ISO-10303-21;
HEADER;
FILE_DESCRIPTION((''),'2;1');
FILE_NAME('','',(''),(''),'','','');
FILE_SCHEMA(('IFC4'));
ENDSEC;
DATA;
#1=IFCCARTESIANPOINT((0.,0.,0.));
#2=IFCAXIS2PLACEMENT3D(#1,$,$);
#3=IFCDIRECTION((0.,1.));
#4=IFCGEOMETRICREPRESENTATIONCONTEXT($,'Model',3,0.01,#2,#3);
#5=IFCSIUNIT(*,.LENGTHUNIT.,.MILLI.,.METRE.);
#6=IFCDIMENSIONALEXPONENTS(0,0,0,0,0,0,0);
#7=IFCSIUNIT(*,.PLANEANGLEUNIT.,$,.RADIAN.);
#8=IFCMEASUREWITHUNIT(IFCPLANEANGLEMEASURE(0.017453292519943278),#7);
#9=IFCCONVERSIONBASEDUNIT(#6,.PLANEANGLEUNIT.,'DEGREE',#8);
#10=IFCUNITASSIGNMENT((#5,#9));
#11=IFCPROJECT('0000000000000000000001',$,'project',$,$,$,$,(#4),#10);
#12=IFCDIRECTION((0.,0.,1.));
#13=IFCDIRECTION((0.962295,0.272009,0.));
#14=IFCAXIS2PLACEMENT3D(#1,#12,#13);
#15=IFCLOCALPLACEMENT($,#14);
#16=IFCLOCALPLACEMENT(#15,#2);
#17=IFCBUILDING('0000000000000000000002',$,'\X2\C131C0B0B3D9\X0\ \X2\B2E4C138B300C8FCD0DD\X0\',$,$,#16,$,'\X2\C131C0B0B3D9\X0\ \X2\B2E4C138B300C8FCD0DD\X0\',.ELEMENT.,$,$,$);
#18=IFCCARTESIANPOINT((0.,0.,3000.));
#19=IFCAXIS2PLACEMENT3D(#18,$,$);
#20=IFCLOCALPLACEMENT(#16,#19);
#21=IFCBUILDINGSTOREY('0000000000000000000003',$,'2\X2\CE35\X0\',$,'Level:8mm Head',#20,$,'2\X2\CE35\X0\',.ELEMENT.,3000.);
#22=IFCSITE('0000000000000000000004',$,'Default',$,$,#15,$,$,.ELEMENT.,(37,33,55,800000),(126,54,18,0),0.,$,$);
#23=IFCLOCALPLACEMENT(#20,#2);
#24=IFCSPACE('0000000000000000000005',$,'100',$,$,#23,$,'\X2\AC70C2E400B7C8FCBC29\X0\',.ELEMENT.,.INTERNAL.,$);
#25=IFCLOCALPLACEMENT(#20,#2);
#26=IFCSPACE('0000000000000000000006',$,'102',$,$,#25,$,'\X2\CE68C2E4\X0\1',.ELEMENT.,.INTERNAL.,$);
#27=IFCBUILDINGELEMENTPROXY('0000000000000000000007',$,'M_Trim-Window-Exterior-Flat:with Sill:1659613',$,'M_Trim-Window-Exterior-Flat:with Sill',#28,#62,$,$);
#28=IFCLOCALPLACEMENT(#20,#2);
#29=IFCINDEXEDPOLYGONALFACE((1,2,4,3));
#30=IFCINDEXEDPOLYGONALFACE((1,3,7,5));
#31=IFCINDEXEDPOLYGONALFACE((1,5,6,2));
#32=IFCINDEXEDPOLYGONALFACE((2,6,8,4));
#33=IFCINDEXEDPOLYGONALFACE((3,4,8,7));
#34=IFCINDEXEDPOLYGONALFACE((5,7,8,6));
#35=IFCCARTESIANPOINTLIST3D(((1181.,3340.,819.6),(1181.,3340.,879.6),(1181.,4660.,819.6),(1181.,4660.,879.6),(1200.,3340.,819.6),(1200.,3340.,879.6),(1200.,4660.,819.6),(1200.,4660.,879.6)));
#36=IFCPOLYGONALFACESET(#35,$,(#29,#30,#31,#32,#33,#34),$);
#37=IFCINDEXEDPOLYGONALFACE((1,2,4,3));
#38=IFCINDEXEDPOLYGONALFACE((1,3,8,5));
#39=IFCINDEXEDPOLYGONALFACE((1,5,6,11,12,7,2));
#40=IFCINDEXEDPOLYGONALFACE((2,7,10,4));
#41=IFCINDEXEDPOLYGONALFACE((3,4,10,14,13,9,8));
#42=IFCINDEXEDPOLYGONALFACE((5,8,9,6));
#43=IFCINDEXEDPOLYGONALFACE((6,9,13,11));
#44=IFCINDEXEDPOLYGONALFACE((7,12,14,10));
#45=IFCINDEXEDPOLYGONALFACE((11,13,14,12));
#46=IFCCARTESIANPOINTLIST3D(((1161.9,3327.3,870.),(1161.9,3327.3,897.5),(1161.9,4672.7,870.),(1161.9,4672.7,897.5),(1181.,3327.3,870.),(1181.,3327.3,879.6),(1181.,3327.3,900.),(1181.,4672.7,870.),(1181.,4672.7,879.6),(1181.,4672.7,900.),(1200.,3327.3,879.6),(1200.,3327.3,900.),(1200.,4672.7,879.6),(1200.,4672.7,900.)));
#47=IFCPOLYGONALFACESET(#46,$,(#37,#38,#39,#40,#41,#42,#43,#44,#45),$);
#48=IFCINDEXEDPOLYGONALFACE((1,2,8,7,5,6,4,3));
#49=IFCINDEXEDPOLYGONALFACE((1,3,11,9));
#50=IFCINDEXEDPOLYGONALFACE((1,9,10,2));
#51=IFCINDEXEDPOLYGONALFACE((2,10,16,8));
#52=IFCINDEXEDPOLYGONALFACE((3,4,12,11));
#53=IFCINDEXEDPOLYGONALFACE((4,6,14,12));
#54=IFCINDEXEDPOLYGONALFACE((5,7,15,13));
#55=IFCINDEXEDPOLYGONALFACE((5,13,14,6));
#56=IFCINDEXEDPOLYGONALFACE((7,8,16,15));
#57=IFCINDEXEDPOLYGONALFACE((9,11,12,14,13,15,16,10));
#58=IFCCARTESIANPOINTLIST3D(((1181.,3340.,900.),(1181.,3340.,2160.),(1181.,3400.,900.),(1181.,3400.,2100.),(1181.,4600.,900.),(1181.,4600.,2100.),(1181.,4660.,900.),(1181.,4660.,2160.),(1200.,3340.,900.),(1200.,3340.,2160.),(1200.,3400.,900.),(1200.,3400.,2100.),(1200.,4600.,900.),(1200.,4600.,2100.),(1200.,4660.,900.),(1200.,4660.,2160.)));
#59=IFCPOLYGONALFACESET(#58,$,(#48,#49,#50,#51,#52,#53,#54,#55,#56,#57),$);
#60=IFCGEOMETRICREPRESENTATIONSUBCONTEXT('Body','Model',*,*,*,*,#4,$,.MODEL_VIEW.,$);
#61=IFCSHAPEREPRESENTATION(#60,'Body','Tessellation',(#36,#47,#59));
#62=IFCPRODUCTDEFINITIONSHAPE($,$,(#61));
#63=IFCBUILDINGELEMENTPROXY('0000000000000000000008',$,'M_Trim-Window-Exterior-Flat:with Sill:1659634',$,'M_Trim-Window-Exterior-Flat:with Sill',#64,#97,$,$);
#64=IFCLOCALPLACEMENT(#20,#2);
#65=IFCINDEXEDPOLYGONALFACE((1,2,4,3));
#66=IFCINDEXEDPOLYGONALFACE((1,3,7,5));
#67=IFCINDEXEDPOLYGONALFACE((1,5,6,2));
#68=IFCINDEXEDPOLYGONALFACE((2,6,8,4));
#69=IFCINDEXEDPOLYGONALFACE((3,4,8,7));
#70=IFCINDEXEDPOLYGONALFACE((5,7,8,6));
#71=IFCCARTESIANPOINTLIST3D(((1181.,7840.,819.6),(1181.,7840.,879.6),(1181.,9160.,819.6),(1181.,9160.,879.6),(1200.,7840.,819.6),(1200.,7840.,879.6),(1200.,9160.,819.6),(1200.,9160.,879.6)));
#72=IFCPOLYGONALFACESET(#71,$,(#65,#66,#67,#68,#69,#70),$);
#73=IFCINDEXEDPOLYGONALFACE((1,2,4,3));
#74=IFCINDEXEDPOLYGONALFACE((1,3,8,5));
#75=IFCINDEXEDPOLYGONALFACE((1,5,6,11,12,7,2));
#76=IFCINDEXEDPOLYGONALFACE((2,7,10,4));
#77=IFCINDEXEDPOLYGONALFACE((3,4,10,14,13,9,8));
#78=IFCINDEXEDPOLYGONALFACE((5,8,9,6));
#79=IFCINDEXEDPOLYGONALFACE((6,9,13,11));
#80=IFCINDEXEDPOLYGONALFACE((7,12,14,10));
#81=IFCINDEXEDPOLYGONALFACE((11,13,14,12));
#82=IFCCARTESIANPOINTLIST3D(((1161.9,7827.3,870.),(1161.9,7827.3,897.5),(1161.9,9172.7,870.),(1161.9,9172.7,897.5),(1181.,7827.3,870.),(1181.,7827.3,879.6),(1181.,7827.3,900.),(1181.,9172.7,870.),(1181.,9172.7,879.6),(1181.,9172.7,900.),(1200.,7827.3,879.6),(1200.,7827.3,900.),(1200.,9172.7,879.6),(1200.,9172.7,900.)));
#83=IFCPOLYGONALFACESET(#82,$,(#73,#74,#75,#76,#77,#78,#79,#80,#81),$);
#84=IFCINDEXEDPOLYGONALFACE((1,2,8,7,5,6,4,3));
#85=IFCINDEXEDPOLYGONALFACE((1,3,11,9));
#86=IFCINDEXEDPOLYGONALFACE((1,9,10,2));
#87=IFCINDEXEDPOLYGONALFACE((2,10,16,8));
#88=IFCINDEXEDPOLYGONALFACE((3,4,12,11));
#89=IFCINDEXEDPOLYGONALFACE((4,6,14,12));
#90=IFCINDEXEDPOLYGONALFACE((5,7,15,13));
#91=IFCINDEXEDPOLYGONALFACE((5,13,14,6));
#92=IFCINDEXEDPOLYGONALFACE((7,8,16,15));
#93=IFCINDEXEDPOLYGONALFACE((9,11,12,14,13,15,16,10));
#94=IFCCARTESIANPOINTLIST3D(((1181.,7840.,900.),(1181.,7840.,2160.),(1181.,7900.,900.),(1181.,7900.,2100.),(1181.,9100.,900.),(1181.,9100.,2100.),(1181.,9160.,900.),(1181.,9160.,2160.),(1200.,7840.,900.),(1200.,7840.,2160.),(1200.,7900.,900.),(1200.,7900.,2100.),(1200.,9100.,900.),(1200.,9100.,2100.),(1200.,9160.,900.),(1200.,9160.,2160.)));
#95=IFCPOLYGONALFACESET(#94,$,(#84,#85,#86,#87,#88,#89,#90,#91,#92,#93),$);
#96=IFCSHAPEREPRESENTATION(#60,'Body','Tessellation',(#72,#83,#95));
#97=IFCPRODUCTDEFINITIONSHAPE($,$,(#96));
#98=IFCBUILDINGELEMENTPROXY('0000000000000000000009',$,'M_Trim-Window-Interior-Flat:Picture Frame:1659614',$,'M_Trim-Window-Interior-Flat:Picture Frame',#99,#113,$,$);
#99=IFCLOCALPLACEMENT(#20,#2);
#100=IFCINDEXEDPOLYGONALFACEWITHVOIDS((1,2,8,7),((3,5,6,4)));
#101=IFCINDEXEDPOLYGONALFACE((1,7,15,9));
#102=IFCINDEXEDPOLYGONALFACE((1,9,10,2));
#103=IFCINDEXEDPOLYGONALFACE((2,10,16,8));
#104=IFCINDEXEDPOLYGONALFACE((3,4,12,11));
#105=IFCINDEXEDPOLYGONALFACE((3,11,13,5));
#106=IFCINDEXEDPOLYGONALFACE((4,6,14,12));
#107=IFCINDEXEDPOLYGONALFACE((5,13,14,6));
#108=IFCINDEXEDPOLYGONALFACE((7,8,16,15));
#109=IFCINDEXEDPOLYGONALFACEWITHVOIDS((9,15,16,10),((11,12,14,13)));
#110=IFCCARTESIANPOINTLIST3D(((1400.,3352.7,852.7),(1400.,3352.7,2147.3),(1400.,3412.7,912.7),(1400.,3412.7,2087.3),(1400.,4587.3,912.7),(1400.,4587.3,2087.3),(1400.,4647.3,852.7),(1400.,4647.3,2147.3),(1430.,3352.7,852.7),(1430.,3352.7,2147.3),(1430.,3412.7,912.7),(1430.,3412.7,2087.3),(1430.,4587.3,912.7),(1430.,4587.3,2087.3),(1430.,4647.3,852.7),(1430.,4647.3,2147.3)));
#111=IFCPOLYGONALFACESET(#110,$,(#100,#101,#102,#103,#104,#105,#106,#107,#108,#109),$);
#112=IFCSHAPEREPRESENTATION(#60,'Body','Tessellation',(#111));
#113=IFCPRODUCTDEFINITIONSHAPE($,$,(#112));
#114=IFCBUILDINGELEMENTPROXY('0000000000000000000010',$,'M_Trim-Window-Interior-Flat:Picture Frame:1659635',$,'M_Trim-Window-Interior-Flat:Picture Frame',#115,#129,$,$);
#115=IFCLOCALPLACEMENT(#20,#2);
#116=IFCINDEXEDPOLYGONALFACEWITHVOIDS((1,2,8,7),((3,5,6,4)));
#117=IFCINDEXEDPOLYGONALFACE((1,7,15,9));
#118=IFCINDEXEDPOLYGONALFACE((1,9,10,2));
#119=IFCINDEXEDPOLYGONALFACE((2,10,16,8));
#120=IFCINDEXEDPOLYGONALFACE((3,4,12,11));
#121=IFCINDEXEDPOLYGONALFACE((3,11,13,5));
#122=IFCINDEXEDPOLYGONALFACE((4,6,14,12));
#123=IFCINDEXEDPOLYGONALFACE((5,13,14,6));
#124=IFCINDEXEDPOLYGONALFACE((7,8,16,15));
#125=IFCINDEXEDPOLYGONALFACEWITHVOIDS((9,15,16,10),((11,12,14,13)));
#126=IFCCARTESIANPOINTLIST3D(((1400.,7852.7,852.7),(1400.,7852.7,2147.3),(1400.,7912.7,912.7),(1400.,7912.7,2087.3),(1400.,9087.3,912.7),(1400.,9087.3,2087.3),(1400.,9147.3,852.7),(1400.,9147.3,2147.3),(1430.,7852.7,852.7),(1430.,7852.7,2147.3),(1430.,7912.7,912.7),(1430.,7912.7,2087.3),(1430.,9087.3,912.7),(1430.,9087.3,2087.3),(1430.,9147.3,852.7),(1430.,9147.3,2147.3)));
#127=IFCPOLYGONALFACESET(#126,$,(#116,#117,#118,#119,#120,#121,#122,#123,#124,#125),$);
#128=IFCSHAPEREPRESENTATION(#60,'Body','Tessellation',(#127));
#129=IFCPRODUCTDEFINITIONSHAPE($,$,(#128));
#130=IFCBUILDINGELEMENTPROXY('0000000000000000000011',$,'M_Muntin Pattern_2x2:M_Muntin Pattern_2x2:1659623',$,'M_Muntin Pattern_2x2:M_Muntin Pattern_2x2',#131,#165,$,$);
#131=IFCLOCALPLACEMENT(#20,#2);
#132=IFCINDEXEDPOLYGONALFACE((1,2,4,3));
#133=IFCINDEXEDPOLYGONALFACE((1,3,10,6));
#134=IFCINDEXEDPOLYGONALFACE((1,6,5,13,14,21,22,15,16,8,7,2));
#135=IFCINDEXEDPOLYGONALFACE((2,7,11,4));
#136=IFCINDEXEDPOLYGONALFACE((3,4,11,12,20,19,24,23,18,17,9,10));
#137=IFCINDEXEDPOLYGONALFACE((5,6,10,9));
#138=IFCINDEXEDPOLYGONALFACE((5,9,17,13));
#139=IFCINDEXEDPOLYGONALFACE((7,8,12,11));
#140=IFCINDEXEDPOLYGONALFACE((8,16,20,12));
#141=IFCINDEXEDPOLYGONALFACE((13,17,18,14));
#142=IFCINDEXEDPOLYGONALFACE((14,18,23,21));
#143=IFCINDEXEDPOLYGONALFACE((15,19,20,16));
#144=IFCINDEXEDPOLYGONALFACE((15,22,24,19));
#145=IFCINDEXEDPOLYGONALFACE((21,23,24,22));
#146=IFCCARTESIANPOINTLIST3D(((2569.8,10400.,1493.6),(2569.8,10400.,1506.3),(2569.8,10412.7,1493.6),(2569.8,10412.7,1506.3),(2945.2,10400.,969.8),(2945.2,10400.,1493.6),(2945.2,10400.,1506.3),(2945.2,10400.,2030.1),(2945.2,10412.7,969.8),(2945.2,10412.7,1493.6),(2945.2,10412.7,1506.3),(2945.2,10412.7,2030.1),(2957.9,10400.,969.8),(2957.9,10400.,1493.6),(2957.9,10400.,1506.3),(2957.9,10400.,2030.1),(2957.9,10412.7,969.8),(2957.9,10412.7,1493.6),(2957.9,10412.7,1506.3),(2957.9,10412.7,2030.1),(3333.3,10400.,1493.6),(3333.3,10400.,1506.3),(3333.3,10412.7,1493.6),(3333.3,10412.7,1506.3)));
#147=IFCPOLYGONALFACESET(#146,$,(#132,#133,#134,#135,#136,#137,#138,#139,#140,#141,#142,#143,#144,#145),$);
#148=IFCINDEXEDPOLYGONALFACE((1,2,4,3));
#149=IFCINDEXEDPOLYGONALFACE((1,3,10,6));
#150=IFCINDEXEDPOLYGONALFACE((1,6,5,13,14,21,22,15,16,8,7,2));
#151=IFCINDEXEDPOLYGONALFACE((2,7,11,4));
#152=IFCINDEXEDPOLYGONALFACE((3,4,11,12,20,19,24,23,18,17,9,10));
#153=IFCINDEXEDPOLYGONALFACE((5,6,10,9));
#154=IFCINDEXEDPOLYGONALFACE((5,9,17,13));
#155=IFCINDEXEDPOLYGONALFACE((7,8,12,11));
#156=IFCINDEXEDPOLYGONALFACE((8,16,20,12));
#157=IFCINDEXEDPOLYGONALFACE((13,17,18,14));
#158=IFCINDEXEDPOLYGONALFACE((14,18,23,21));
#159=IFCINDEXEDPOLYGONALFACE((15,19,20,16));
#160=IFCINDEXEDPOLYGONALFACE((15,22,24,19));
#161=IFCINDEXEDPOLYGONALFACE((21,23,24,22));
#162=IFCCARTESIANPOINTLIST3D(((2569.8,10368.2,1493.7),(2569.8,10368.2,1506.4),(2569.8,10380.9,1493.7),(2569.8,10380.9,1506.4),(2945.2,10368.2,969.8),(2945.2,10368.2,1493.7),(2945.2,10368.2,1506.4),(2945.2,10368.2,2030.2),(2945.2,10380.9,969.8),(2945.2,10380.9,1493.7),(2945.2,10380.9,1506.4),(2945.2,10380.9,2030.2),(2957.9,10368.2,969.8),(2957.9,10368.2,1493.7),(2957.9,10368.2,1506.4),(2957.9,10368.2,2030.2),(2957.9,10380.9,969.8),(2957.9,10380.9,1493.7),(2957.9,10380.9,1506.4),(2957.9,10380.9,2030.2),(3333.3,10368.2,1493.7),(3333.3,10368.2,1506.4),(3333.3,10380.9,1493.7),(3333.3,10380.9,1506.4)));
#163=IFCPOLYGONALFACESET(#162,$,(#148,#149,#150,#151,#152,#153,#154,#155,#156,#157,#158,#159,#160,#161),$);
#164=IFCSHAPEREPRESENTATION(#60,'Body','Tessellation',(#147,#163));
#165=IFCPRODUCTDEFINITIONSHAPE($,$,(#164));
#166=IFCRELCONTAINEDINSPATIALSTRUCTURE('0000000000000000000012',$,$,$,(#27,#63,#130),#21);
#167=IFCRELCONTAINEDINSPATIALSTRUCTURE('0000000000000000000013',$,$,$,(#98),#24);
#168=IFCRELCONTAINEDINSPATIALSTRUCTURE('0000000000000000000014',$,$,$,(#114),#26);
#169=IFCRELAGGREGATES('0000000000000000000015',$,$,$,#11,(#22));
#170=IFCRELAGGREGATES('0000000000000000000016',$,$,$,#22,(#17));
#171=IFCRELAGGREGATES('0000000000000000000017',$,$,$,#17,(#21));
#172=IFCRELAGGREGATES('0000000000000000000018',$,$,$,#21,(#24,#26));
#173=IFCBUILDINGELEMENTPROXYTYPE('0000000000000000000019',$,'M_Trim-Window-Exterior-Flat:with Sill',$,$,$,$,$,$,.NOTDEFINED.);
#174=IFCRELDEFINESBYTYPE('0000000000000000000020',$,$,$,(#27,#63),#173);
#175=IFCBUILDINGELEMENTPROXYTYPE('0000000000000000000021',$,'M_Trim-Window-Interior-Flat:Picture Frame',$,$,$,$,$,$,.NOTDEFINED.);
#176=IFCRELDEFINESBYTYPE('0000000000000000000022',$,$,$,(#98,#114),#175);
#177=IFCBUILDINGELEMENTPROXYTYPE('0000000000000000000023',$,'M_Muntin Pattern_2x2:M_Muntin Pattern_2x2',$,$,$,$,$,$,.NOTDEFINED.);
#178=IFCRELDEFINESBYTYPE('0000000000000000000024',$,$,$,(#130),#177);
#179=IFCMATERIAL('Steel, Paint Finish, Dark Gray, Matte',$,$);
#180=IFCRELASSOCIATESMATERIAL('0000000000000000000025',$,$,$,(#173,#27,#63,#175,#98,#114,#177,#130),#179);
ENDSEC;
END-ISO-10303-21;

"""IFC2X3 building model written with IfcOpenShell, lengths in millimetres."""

from ifc_helpers import new_model, entity, si_unit, converted_unit, direction, frame, frame_2d, origin, place, context, subcontext, project, spatial, polyline, rectangle, outline, extrude, source, transform, mapped, material, type_object, type_shapes, element, save


model = new_model("IFC2X3")

# Units and contexts
model_context = context("Model", 3, precision=0.01, world=origin(), true_north=direction((0.0, 1.0)))
body_context = subcontext(model_context, "Body", "Model", "MODEL_VIEW")
ifc_project = project(units=[si_unit("LENGTHUNIT", "METRE", prefix="MILLI"), converted_unit("PLANEANGLEUNIT", "DEGREE", entity("IfcPlaneAngleMeasure", 0.017453292519943278), si_unit("PLANEANGLEUNIT", "RADIAN"), dimensions=[0, 0, 0, 0, 0, 0, 0])], contexts=[model_context])

# Site, building, storey
site_placement = place(None, frame((0.0, 0.0, 0.0), z_axis=(0.0, 0.0, 1.0), x_axis=(0.962295, 0.272009, 0.0)))
site = spatial("IfcSite", under=ifc_project, at=site_placement, Name="Default", CompositionType="ELEMENT", RefLatitude=(37, 33, 55, 800000), RefLongitude=(126, 54, 18, 0), RefElevation=0.0)
building_placement = place(site_placement, origin())
building = spatial("IfcBuilding", under=site, at=building_placement, Name="성산동 다세대주택", LongName="성산동 다세대주택", CompositionType="ELEMENT")
storey_placement = place(building_placement, frame((0.0, 0.0, 3000.0)))
storey = spatial("IfcBuildingStorey", under=building, at=storey_placement, Name="2층", ObjectType="Level:8mm Head", LongName="2층", CompositionType="ELEMENT", Elevation=3000.0)

# Shared definitions
space_1_placement = place(storey_placement, origin())
space_1 = spatial("IfcSpace", under=storey, at=space_1_placement, Name="100", LongName="거실·주방", CompositionType="ELEMENT", InteriorOrExteriorSpace="INTERNAL")

# Shared definitions
space_2_placement = place(storey_placement, origin())
space_2 = spatial("IfcSpace", under=storey, at=space_2_placement, Name="102", LongName="침실1", CompositionType="ELEMENT", InteriorOrExteriorSpace="INTERNAL")

# Building element proxies
ifc_material_1 = material(Name="Steel, Paint Finish, Dark Gray, Matte")
building_element_proxy_type_1 = type_object("IfcBuildingElementProxyType", Name="M_Trim-Window-Exterior-Flat:with Sill", PredefinedType="NOTDEFINED", material=ifc_material_1)
shared_shape_1 = source(origin(), body_context, "Body", "SweptSolid", [
    extrude(rectangle(XDim=1320.0, YDim=60.0, at=frame_2d((0.0, 0.0), x_axis=(1.0, 0.0))), frame((0.0, -1250.4, 0.0), z_axis=(0.0, 0.0, 1.0), x_axis=(-1.0, 0.0, 0.0)), (0.0, 0.0, 1.0), 19.0),
    extrude(outline(polyline([(-19.0, -15.2), (0.0, -15.2), (0.0, -5.7), (19.0, -5.7), (19.0, 14.8), (0.0, 14.8), (-19.0, 12.3), (-19.0, -15.2)])), frame((-672.7, -1214.8, 19.0), z_axis=(1.0, 0.0, 0.0), x_axis=(0.0, 0.0, -1.0)), (0.0, 0.0, 1.0), 1345.4),
    extrude(outline(polyline([(-645.0, -660.0), (615.0, -660.0), (615.0, -600.0), (-585.0, -600.0), (-585.0, 600.0), (615.0, 600.0), (615.0, 660.0), (-645.0, 660.0), (-645.0, -660.0)])), frame((0.0, -585.0, 0.0), z_axis=(0.0, 0.0, 1.0), x_axis=(0.0, -1.0, 0.0)), (0.0, 0.0, 1.0), 19.0),
])
type_shapes(building_element_proxy_type_1, [shared_shape_1])
for number, where, z_axis, x_axis, name in (
    (1, (1200.0, 4000.0, 2100.0), (-1.0, 0.0, 0.0), (0.0, -1.0, 0.0), "M_Trim-Window-Exterior-Flat:with Sill:1659613"),
    (2, (1200.0, 8500.0, 2100.0), (-1.0, 0.0, 0.0), (0.0, -1.0, 0.0), "M_Trim-Window-Exterior-Flat:with Sill:1659634"),
):
    element("IfcBuildingElementProxy", number, at=place(storey_placement, frame(where, z_axis=z_axis, x_axis=x_axis)), inside=storey, type_object=building_element_proxy_type_1, material=ifc_material_1, Name=name, ObjectType="M_Trim-Window-Exterior-Flat:with Sill", context=body_context, shape_type="MappedRepresentation", body=[
        mapped(shared_shape_1, transform((0.0, 0.0, 0.0), scale=1.0)),
    ])
building_element_proxy_type_2 = type_object("IfcBuildingElementProxyType", Name="M_Trim-Window-Interior-Flat:Picture Frame", PredefinedType="NOTDEFINED", material=ifc_material_1)
shared_shape_2 = source(origin(), body_context, "Body", "SweptSolid", [
    extrude(outline(polyline([(-647.3, -647.3), (647.3, -647.3), (647.3, 647.3), (-647.3, 647.3), (-647.3, -647.3)]), holes=[polyline([(-587.3, -587.3), (-587.3, 587.3), (587.3, 587.3), (587.3, -587.3), (-587.3, -587.3)])]), frame((0.0, -600.0, 0.0), z_axis=(0.0, 0.0, 1.0), x_axis=(-1.0, 0.0, 0.0)), (0.0, 0.0, 1.0), 30.0),
])
type_shapes(building_element_proxy_type_2, [shared_shape_2])
proxy_1_placement = place(space_1_placement, frame((1400.0, 4000.0, 2100.0), z_axis=(1.0, 0.0, 0.0), x_axis=(0.0, 1.0, 0.0)))
element("IfcBuildingElementProxy", 3, at=proxy_1_placement, inside=space_1, type_object=building_element_proxy_type_2, material=ifc_material_1, Name="M_Trim-Window-Interior-Flat:Picture Frame:1659614", ObjectType="M_Trim-Window-Interior-Flat:Picture Frame", context=body_context, shape_type="MappedRepresentation", body=[
    mapped(shared_shape_2, transform((0.0, 0.0, 0.0), scale=1.0)),
])
proxy_2_placement = place(space_2_placement, frame((1400.0, 8500.0, 2100.0), z_axis=(1.0, 0.0, 0.0), x_axis=(0.0, 1.0, 0.0)))
element("IfcBuildingElementProxy", 4, at=proxy_2_placement, inside=space_2, type_object=building_element_proxy_type_2, material=ifc_material_1, Name="M_Trim-Window-Interior-Flat:Picture Frame:1659635", ObjectType="M_Trim-Window-Interior-Flat:Picture Frame", context=body_context, shape_type="MappedRepresentation", body=[
    mapped(shared_shape_2, transform((0.0, 0.0, 0.0), scale=1.0)),
])
building_element_proxy_type_3 = type_object("IfcBuildingElementProxyType", Name="M_Muntin Pattern_2x2:M_Muntin Pattern_2x2", PredefinedType="NOTDEFINED", material=ifc_material_1)
shared_shape_3 = source(origin(), body_context, "Body", "SweptSolid", [
    extrude(outline(polyline([(6.4, -6.4), (530.1, -6.4), (530.1, 6.3), (6.4, 6.3), (6.4, 381.7), (-6.3, 381.7), (-6.3, 6.3), (-530.2, 6.3), (-530.2, -6.4), (-6.3, -6.4), (-6.3, -381.7), (6.4, -381.7), (6.4, -6.4)])), frame((0.0, 9.5, 530.1), z_axis=(0.0, 1.0, 0.0), x_axis=(0.0, 0.0, 1.0)), (0.0, 0.0, 1.0), 12.7),
    extrude(outline(polyline([(6.4, -6.4), (530.2, -6.4), (530.2, 6.3), (6.4, 6.3), (6.4, 381.7), (-6.3, 381.7), (-6.3, 6.3), (-530.2, 6.3), (-530.2, -6.4), (-6.3, -6.4), (-6.3, -381.7), (6.4, -381.7), (6.4, -6.4)])), frame((0.0, -22.2, 530.2), z_axis=(0.0, 1.0, 0.0), x_axis=(0.0, 0.0, 1.0)), (0.0, 0.0, 1.0), 12.7),
])
type_shapes(building_element_proxy_type_3, [shared_shape_3])
proxy_3_placement = place(storey_placement, frame((2951.6, 10390.5, 969.8)))
element("IfcBuildingElementProxy", 5, at=proxy_3_placement, inside=storey, type_object=building_element_proxy_type_3, material=ifc_material_1, Name="M_Muntin Pattern_2x2:M_Muntin Pattern_2x2:1659623", ObjectType="M_Muntin Pattern_2x2:M_Muntin Pattern_2x2", context=body_context, shape_type="MappedRepresentation", body=[
    mapped(shared_shape_3, transform((0.0, 0.0, 0.0), scale=1.0)),
])

save(model, "model.ifc")
